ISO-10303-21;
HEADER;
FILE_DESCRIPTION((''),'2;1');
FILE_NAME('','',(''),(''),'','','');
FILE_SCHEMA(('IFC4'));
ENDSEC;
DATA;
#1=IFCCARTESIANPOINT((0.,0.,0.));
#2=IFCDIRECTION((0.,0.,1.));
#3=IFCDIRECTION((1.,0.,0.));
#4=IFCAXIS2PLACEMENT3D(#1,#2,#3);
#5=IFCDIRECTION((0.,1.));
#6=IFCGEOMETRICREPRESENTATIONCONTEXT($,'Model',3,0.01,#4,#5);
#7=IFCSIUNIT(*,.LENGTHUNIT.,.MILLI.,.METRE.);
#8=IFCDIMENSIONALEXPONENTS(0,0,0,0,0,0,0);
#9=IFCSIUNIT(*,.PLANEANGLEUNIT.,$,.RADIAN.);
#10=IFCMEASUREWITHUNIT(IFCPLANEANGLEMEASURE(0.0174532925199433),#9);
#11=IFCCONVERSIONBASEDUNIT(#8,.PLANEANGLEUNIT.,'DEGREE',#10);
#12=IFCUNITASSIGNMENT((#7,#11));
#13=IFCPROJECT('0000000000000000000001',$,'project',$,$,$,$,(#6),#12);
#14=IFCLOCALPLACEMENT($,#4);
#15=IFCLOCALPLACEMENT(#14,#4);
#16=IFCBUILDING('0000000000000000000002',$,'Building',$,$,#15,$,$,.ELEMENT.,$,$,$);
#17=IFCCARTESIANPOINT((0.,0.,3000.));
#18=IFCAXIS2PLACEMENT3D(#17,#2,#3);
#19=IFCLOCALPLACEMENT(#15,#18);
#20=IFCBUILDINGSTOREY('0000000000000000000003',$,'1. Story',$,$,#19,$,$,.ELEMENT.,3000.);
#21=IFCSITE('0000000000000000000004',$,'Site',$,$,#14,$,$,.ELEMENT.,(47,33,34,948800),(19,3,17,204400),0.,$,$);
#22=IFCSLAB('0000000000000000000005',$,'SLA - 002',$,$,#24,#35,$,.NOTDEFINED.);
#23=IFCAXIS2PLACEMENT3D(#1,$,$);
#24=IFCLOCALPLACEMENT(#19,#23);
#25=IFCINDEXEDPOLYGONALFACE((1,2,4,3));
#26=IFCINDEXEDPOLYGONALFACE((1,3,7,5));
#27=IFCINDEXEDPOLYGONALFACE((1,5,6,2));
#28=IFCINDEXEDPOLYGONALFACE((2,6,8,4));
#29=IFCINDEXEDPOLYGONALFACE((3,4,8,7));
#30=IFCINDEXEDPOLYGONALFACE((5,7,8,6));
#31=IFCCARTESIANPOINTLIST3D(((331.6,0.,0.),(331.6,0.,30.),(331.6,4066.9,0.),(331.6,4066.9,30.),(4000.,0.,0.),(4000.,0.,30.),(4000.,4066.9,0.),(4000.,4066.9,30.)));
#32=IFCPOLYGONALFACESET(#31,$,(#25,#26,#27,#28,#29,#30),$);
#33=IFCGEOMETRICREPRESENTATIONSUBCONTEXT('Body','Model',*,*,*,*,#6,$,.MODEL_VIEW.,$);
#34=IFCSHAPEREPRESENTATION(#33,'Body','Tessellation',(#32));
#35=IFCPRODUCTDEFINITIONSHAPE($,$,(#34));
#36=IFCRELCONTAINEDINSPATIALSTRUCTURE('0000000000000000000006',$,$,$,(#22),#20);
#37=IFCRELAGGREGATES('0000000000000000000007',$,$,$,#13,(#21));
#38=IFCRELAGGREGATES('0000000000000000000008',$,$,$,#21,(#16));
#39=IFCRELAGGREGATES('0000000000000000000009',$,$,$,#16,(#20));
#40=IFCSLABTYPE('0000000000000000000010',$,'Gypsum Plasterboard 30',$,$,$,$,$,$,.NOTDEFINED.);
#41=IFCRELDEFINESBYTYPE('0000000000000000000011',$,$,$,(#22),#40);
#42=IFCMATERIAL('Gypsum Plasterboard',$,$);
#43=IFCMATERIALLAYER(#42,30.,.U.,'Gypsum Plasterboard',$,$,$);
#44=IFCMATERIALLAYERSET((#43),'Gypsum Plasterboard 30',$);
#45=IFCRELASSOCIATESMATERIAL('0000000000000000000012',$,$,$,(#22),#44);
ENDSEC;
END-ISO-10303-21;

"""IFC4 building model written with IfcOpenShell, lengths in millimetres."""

from ifc_helpers import new_model, entity, si_unit, converted_unit, direction, frame, origin_with_axes, place, context, subcontext, project, spatial, line, indexed_curve, outline, extrude, material, layer, layer_set, layer_usage, type_object, element, save


model = new_model("IFC4")

# Units and contexts
model_context = context("Model", 3, precision=0.01, world=origin_with_axes(), true_north=direction((0.0, 1.0)))
body_context = subcontext(model_context, "Body", "Model", "MODEL_VIEW")
ifc_project = project(units=[si_unit("LENGTHUNIT", "METRE", prefix="MILLI"), converted_unit("PLANEANGLEUNIT", "DEGREE", entity("IfcPlaneAngleMeasure", 0.0174532925199433), si_unit("PLANEANGLEUNIT", "RADIAN"), dimensions=[0, 0, 0, 0, 0, 0, 0])], contexts=[model_context])

# Site, building, storey
site_placement = place(None, origin_with_axes())
site = spatial("IfcSite", under=ifc_project, at=site_placement, Name="Site", CompositionType="ELEMENT", RefLatitude=(47, 33, 34, 948800), RefLongitude=(19, 3, 17, 204400), RefElevation=0.0)
building_placement = place(site_placement, origin_with_axes())
building = spatial("IfcBuilding", under=site, at=building_placement, Name="Building", CompositionType="ELEMENT")
storey_placement = place(building_placement, frame((0.0, 0.0, 3000.0), z_axis=(0.0, 0.0, 1.0), x_axis=(1.0, 0.0, 0.0)))
storey = spatial("IfcBuildingStorey", under=building, at=storey_placement, Name="1. Story", CompositionType="ELEMENT", Elevation=3000.0)

# Slab
ifc_material = material(Name="Gypsum Plasterboard")
ifc_layer = layer(ifc_material, 30.0, ventilated="UNKNOWN", Name="Gypsum Plasterboard")
ifc_layer_set = layer_set([ifc_layer], Name="Gypsum Plasterboard 30")
ifc_layer_usage = layer_usage(ifc_layer_set, "AXIS3", "NEGATIVE", 30.0)
slab_type = type_object("IfcSlabType", Name="Gypsum Plasterboard 30", PredefinedType="NOTDEFINED")
slab_placement = place(storey_placement, frame((331.6, 0.0, 0.0), z_axis=(0.0, 0.0, 1.0), x_axis=(1.0, 0.0, 0.0)))
element("IfcSlab", 1, at=slab_placement, inside=storey, type_object=slab_type, material=ifc_layer_usage, Name="SLA - 002", PredefinedType="NOTDEFINED", context=body_context, shape_type="SweptSolid", body=[
    extrude(outline(indexed_curve([(0.0, 0.0), (3668.4, 0.0), (3668.4, 4066.9), (0.0, 4066.9)], segments=[line(1, 2, 3, 4, 1)])), origin_with_axes(), (0.0, 0.0, 1.0), 30.0),
])

save(model, "model.ifc")
